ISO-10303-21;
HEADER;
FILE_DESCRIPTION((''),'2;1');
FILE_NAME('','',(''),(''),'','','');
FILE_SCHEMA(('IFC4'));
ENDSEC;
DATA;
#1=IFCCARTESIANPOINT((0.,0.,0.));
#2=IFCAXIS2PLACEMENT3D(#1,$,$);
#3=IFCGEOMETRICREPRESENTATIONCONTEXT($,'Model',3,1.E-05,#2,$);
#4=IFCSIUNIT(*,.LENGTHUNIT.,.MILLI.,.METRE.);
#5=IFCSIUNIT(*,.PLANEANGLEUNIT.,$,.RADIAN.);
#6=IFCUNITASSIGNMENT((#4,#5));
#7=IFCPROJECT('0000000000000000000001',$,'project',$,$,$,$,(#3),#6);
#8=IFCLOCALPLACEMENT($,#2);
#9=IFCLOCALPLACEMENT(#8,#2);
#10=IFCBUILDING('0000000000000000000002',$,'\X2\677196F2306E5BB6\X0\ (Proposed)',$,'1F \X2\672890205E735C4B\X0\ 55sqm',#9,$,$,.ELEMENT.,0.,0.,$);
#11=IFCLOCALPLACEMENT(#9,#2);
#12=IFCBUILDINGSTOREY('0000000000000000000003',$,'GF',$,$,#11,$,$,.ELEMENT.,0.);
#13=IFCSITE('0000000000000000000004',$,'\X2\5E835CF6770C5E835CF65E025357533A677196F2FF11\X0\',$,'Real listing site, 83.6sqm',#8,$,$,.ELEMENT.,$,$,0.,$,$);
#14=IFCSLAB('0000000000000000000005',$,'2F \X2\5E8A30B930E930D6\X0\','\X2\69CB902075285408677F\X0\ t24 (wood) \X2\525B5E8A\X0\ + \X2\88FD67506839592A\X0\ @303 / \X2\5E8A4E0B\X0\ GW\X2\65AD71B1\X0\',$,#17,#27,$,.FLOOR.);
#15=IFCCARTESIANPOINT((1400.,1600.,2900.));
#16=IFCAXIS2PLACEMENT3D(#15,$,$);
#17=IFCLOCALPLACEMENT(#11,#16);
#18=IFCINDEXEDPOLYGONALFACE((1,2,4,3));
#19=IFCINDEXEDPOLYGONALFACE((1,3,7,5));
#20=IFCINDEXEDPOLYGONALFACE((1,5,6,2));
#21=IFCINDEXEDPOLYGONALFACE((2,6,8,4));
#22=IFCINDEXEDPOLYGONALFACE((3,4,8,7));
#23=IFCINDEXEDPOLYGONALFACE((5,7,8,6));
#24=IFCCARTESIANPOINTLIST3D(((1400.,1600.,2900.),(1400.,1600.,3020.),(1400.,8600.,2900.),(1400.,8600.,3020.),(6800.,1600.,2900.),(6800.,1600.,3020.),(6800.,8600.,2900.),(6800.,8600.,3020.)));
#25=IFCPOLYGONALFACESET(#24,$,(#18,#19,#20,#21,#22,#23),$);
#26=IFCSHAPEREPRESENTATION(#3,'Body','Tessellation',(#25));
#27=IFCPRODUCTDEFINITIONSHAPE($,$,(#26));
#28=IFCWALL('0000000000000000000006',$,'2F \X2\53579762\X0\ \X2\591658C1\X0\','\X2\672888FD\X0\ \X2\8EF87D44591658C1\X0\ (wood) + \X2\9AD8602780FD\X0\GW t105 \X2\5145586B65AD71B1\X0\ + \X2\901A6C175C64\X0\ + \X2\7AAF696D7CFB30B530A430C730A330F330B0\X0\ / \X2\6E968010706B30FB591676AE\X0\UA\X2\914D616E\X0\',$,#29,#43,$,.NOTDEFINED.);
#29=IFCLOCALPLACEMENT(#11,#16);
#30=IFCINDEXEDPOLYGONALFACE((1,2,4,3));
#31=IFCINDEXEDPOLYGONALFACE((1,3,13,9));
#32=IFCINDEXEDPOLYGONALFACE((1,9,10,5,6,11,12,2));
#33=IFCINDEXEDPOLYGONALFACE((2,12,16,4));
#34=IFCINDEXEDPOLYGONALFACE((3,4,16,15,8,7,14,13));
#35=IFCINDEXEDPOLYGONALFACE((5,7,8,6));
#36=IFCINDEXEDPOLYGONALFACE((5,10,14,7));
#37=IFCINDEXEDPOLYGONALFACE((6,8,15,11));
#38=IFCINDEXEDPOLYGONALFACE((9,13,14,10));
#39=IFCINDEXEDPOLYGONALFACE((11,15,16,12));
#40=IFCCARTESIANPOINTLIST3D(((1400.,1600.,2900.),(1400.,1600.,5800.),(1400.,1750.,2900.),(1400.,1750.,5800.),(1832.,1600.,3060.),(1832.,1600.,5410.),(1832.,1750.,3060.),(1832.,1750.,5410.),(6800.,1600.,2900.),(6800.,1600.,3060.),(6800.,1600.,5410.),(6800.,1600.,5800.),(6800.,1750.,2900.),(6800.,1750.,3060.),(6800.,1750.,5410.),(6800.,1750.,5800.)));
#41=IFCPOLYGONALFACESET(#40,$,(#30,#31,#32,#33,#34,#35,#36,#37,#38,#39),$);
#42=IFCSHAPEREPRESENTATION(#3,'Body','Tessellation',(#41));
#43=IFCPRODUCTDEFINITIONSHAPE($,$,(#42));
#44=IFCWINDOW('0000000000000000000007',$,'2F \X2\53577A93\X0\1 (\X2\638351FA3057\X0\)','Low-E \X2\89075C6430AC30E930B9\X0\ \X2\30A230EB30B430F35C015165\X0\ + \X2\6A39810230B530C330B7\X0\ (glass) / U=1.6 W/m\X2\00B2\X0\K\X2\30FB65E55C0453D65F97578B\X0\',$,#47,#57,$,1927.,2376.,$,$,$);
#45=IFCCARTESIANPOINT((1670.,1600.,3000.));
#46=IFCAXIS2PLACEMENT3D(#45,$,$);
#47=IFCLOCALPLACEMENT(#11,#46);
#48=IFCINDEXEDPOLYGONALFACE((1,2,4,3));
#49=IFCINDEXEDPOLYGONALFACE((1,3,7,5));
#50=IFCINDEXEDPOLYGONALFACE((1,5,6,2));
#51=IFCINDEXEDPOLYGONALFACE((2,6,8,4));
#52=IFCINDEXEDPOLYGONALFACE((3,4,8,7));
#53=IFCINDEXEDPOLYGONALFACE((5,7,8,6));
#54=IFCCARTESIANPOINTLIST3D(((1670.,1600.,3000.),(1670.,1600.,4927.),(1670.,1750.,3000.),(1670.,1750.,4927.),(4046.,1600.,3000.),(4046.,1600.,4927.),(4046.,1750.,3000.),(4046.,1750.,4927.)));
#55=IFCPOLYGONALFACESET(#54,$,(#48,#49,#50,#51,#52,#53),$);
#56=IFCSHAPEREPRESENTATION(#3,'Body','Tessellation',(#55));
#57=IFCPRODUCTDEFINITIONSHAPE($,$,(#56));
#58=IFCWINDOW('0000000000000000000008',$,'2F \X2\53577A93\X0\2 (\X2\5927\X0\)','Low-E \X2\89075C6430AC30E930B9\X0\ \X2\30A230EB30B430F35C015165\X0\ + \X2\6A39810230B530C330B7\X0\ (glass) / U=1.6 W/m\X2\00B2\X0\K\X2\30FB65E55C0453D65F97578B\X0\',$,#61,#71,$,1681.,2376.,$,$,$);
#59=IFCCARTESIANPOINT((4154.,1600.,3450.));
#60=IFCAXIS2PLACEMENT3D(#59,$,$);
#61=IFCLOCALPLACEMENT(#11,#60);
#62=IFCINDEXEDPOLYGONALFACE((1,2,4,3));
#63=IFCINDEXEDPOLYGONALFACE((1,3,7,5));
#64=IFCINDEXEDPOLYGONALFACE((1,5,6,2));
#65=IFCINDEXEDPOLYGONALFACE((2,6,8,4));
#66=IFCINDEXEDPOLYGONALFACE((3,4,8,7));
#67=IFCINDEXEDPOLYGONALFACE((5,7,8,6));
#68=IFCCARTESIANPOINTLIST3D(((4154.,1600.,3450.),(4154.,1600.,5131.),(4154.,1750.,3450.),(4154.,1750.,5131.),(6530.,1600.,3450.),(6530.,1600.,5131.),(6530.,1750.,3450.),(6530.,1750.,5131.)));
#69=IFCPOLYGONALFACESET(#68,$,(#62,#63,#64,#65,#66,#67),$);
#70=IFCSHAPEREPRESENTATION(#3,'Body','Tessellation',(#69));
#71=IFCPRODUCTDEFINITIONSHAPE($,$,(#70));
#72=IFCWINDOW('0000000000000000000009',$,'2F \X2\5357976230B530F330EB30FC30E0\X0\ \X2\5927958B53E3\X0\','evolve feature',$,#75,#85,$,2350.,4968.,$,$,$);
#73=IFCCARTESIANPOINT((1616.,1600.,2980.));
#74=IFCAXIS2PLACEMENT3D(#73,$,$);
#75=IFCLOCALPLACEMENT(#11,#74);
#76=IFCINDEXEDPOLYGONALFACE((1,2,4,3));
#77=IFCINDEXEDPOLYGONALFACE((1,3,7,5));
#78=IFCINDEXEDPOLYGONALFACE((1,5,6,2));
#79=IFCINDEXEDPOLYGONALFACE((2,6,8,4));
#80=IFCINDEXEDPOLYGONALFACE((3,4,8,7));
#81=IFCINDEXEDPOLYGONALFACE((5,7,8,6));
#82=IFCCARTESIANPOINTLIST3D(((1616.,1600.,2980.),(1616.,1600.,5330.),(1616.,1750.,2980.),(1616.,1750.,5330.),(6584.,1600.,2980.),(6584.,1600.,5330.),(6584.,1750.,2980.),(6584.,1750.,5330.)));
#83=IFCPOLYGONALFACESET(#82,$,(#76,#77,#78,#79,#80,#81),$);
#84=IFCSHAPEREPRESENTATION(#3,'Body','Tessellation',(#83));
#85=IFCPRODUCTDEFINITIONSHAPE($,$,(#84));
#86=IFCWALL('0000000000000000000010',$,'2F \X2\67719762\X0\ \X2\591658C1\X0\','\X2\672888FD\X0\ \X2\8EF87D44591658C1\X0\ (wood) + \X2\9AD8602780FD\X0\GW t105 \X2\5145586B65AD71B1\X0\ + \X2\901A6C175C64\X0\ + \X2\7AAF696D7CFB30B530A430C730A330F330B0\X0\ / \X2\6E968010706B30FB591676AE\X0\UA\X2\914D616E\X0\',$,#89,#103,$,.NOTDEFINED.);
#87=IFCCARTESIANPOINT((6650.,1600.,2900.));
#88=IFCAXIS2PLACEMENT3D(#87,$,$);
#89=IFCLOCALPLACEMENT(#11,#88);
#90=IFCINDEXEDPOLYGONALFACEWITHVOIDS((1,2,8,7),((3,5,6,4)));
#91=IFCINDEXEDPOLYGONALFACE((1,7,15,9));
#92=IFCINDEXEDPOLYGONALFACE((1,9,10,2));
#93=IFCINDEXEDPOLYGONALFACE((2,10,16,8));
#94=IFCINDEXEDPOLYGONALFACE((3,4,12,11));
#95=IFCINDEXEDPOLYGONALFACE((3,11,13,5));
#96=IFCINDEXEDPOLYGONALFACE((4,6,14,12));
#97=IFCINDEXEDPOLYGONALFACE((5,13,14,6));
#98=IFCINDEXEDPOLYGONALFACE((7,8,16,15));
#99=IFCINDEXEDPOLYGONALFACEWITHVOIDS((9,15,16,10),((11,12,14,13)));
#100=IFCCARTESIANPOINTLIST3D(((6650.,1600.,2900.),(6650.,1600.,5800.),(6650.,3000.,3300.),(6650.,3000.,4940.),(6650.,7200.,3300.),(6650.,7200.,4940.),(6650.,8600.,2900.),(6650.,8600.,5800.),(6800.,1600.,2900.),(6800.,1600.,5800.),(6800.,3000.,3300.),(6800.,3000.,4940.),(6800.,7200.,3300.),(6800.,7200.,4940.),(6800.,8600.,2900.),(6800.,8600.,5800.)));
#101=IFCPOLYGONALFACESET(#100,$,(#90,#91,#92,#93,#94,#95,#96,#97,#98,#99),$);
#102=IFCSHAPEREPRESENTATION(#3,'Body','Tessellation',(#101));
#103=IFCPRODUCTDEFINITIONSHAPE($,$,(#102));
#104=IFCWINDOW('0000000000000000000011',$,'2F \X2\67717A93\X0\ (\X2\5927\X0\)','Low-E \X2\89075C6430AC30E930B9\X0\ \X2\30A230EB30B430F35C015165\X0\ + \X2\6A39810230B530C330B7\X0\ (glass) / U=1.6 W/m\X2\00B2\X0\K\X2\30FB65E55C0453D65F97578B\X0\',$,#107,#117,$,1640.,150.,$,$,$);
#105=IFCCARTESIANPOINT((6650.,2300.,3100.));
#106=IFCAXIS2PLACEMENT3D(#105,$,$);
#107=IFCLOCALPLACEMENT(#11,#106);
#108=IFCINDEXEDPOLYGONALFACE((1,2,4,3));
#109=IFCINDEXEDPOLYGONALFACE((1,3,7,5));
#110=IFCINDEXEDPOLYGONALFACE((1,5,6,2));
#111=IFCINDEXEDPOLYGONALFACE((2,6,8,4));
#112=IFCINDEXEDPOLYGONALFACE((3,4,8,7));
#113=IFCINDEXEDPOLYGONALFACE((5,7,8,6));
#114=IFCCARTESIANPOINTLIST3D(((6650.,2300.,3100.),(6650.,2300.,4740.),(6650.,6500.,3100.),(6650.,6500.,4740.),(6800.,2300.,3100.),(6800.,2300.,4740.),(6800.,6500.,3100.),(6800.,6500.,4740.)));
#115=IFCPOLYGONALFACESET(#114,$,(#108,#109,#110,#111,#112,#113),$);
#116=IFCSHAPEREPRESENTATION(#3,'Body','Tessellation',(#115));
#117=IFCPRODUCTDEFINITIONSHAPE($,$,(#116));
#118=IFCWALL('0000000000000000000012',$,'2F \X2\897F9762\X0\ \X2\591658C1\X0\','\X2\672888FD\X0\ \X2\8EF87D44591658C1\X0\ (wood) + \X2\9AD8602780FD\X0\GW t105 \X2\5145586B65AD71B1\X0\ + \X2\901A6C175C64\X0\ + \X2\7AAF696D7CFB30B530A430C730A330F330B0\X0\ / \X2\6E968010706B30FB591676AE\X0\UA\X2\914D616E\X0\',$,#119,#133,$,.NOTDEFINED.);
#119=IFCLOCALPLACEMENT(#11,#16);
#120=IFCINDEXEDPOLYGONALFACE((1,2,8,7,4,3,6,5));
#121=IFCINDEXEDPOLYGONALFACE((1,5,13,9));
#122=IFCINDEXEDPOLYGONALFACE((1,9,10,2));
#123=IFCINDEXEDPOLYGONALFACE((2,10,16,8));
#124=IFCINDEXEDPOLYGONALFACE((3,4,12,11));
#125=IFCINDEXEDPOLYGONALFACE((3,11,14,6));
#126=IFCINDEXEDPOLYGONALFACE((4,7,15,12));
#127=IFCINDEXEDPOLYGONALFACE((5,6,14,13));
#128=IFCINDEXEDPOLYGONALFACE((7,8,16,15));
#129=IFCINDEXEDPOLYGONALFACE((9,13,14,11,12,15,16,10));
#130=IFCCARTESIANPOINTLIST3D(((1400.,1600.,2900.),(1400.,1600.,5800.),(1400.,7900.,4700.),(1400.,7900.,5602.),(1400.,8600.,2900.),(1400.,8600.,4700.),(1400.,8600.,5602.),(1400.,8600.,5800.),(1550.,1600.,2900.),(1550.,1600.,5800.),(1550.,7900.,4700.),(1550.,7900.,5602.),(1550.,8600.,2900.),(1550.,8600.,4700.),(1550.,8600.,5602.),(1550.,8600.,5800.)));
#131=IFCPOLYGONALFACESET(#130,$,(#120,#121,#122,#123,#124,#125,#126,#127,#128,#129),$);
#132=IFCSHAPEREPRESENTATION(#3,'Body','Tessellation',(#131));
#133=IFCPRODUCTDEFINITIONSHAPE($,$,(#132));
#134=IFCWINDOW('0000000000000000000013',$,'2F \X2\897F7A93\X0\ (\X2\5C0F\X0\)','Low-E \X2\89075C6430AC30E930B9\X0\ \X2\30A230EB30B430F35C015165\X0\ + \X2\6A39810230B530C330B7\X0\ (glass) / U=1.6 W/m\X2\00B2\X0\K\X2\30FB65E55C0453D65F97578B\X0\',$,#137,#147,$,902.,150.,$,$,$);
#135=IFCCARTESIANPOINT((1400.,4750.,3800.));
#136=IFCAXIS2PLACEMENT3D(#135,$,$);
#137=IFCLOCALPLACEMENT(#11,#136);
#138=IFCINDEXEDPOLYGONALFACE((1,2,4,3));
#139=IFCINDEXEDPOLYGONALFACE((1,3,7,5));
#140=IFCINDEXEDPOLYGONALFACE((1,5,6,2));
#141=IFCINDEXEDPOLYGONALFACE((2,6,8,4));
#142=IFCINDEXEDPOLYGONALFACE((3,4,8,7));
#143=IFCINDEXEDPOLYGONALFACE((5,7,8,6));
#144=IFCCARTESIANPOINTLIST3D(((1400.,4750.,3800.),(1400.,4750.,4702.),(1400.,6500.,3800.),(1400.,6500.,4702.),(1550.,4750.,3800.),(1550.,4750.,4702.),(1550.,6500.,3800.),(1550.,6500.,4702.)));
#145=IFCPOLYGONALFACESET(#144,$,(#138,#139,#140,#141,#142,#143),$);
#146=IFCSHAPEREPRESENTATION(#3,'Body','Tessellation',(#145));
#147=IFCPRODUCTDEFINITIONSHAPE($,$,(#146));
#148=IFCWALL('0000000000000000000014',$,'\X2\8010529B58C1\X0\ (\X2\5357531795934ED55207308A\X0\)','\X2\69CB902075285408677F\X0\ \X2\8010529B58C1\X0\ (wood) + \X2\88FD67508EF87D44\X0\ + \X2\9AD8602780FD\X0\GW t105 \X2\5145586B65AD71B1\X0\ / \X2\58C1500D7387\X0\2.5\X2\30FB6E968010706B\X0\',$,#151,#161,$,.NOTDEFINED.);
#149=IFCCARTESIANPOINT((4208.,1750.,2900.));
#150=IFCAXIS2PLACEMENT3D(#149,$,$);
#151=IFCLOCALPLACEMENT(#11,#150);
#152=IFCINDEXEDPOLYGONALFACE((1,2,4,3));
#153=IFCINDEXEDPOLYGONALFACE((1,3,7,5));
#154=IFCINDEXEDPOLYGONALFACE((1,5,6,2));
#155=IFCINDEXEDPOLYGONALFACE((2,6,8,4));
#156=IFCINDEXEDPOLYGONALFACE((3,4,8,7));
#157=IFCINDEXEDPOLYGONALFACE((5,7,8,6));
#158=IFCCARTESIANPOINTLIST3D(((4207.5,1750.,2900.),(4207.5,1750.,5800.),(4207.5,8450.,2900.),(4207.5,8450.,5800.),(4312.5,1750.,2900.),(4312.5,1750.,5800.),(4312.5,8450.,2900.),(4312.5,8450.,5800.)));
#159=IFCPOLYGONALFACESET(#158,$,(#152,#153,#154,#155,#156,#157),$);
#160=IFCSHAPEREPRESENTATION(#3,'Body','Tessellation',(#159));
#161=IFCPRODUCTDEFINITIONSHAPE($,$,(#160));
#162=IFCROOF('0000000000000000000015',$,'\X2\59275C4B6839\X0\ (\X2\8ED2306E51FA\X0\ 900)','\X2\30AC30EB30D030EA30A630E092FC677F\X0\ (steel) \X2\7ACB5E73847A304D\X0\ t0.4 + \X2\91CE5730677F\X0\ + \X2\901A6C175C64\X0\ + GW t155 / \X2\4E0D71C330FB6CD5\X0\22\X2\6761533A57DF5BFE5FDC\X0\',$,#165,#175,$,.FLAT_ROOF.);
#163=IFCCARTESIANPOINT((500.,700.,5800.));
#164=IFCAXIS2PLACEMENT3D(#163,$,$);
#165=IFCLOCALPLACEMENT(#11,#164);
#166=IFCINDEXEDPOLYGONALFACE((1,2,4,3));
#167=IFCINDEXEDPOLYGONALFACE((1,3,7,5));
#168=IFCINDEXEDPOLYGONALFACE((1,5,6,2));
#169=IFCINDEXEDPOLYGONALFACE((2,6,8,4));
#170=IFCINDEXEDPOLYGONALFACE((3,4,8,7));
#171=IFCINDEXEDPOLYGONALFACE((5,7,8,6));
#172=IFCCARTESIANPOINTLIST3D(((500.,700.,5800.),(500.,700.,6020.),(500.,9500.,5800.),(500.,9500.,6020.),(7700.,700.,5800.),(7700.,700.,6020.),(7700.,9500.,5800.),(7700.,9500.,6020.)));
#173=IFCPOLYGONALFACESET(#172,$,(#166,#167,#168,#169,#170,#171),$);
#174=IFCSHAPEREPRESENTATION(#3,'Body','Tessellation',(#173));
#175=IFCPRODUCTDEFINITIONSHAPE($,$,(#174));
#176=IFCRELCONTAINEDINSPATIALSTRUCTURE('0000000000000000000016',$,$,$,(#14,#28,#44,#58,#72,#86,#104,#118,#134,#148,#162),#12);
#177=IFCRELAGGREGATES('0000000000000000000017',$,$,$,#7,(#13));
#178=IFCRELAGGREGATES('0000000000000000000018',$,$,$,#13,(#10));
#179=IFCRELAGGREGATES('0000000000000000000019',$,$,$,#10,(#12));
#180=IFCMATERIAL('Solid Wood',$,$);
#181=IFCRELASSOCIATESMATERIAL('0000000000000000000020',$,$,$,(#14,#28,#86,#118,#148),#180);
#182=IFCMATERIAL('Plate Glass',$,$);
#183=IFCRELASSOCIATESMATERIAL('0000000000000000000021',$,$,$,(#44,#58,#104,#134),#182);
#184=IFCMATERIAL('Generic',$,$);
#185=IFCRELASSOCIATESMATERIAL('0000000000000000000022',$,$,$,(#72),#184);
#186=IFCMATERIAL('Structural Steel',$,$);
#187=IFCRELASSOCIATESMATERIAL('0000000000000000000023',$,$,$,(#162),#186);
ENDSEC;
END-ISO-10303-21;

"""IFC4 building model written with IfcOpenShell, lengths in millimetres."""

from ifc_helpers import new_model, si_unit, frame, frame_2d, origin, place, context, project, spatial, rectangle, extrude, material, element, fill, save


model = new_model("IFC4")

# Units and contexts
model_context = context("Model", 3, precision=1e-05, world=origin())
ifc_project = project(units=[si_unit("LENGTHUNIT", "METRE", prefix="MILLI"), si_unit("PLANEANGLEUNIT", "RADIAN")], contexts=[model_context])

# Site, building, storey
site_placement = place(None, origin())
site = spatial("IfcSite", under=ifc_project, at=site_placement, Name="広島県広島市南区東雲１", ObjectType="Real listing site, 83.6sqm", CompositionType="ELEMENT", RefElevation=0.0)
building_placement = place(site_placement, origin())
building = spatial("IfcBuilding", under=site, at=building_placement, Name="東雲の家 (Proposed)", ObjectType="1F 木造平屋 55sqm", CompositionType="ELEMENT", ElevationOfRefHeight=0.0, ElevationOfTerrain=0.0)
storey_placement = place(building_placement, origin())
storey = spatial("IfcBuildingStorey", under=building, at=storey_placement, Name="GF", CompositionType="ELEMENT", Elevation=0.0)

# Slab
ifc_material_1 = material(Name="Solid Wood")
slab_placement = place(storey_placement, frame((1400.0, 1600.0, 2900.0)))
element("IfcSlab", 1, at=slab_placement, inside=storey, material=ifc_material_1, Name="2F 床スラブ", Description="構造用合板 t24 (wood) 剛床 + 製材根太 @303 / 床下 GW断熱", PredefinedType="FLOOR", context=model_context, shape_type="SweptSolid", body=[
    extrude(rectangle(XDim=5400.0, YDim=7000.0, at=frame_2d((2700.0, 3500.0))), frame((1400.0, 1600.0, 2900.0)), (0.0, 0.0, 1.0), 120.0),
])

# Wall, openings, windows
wall_1_placement = place(storey_placement, frame((1400.0, 1600.0, 2900.0)))
wall_1 = element("IfcWall", 2, at=wall_1_placement, inside=storey, material=ifc_material_1, Name="2F 南面 外壁", Description="木製 軸組外壁 (wood) + 高性能GW t105 充填断熱 + 通気層 + 窯業系サイディング / 準耐火・外皮UA配慮", PredefinedType="NOTDEFINED", context=model_context, shape_type="SweptSolid", body=[
    extrude(rectangle(XDim=5400.0, YDim=150.0, at=frame_2d((2700.0, 75.0))), frame((1400.0, 1600.0, 2900.0)), (0.0, 0.0, 1.0), 2900.0),
])
opening_1_placement = place(storey_placement, frame((1670.0, 1600.0, 3000.0)))
opening_1 = element("IfcOpeningElement", 3, at=opening_1_placement, cuts=wall_1, PredefinedType="NOTDEFINED", context=model_context, shape_type="SweptSolid", body=[
    extrude(rectangle(XDim=2376.0, YDim=150.0, at=frame_2d((1188.0, 75.0))), frame((1670.0, 1600.0, 3000.0)), (0.0, 0.0, 1.0), 1927.0),
])
opening_2_placement = place(storey_placement, frame((4154.0, 1600.0, 3450.0)))
opening_2 = element("IfcOpeningElement", 4, at=opening_2_placement, cuts=wall_1, PredefinedType="NOTDEFINED", context=model_context, shape_type="SweptSolid", body=[
    extrude(rectangle(XDim=2376.0, YDim=150.0, at=frame_2d((1188.0, 75.0))), frame((4154.0, 1600.0, 3450.0)), (0.0, 0.0, 1.0), 1681.0),
])
opening_3_placement = place(storey_placement, frame((1616.0, 1600.0, 2980.0)))
opening_3 = element("IfcOpeningElement", 5, at=opening_3_placement, cuts=wall_1, PredefinedType="NOTDEFINED", context=model_context, shape_type="SweptSolid", body=[
    extrude(rectangle(XDim=4968.0, YDim=150.0, at=frame_2d((2484.0, 75.0))), frame((1616.0, 1600.0, 2980.0)), (0.0, 0.0, 1.0), 2350.0),
])
ifc_material_2 = material(Name="Plate Glass")
window_1_placement = place(storey_placement, frame((1670.0, 1600.0, 3000.0)))
window_1 = element("IfcWindow", 6, at=window_1_placement, inside=storey, material=ifc_material_2, Name="2F 南窓1 (掃出し)", Description="Low-E 複層ガラス アルゴン封入 + 樹脂サッシ (glass) / U=1.6 W/m²K・日射取得型", OverallHeight=1927.0, OverallWidth=2376.0, context=model_context, shape_type="SweptSolid", body=[
    extrude(rectangle(XDim=2376.0, YDim=150.0, at=frame_2d((1188.0, 75.0))), frame((1670.0, 1600.0, 3000.0)), (0.0, 0.0, 1.0), 1927.0),
])
fill(opening_1, window_1)
window_2_placement = place(storey_placement, frame((4154.0, 1600.0, 3450.0)))
window_2 = element("IfcWindow", 7, at=window_2_placement, inside=storey, material=ifc_material_2, Name="2F 南窓2 (大)", Description="Low-E 複層ガラス アルゴン封入 + 樹脂サッシ (glass) / U=1.6 W/m²K・日射取得型", OverallHeight=1681.0, OverallWidth=2376.0, context=model_context, shape_type="SweptSolid", body=[
    extrude(rectangle(XDim=2376.0, YDim=150.0, at=frame_2d((1188.0, 75.0))), frame((4154.0, 1600.0, 3450.0)), (0.0, 0.0, 1.0), 1681.0),
])
fill(opening_2, window_2)
ifc_material_3 = material(Name="Generic")
window_3_placement = place(storey_placement, frame((1616.0, 1600.0, 2980.0)))
window_3 = element("IfcWindow", 8, at=window_3_placement, inside=storey, material=ifc_material_3, Name="2F 南面サンルーム 大開口", Description="evolve feature", OverallHeight=2350.0, OverallWidth=4968.0, context=model_context, shape_type="SweptSolid", body=[
    extrude(rectangle(XDim=4968.0, YDim=150.0, at=frame_2d((2484.0, 75.0))), frame((1616.0, 1600.0, 2980.0)), (0.0, 0.0, 1.0), 2350.0),
])
fill(opening_3, window_3)

# Walls, openings, windows
wall_2_placement = place(storey_placement, frame((6650.0, 1600.0, 2900.0)))
wall_2 = element("IfcWall", 9, at=wall_2_placement, inside=storey, material=ifc_material_1, Name="2F 東面 外壁", Description="木製 軸組外壁 (wood) + 高性能GW t105 充填断熱 + 通気層 + 窯業系サイディング / 準耐火・外皮UA配慮", PredefinedType="NOTDEFINED", context=model_context, shape_type="SweptSolid", body=[
    extrude(rectangle(XDim=150.0, YDim=7000.0, at=frame_2d((75.0, 3500.0))), frame((6650.0, 1600.0, 2900.0)), (0.0, 0.0, 1.0), 2900.0),
])
opening_4_placement = place(storey_placement, frame((6650.0, 2300.0, 3100.0)))
opening_4 = element("IfcOpeningElement", 10, at=opening_4_placement, cuts=wall_2, PredefinedType="NOTDEFINED", context=model_context, shape_type="SweptSolid", body=[
    extrude(rectangle(XDim=150.0, YDim=4200.0, at=frame_2d((75.0, 2100.0))), frame((6650.0, 2300.0, 3100.0)), (0.0, 0.0, 1.0), 1640.0),
])
window_4_placement = place(storey_placement, frame((6650.0, 2300.0, 3100.0)))
window_4 = element("IfcWindow", 11, at=window_4_placement, inside=storey, material=ifc_material_2, Name="2F 東窓 (大)", Description="Low-E 複層ガラス アルゴン封入 + 樹脂サッシ (glass) / U=1.6 W/m²K・日射取得型", OverallHeight=1640.0, OverallWidth=150.0, context=model_context, shape_type="SweptSolid", body=[
    extrude(rectangle(XDim=150.0, YDim=4200.0, at=frame_2d((75.0, 2100.0))), frame((6650.0, 2300.0, 3100.0)), (0.0, 0.0, 1.0), 1640.0),
])
fill(opening_4, window_4)
wall_3_placement = place(storey_placement, frame((1400.0, 1600.0, 2900.0)))
wall_3 = element("IfcWall", 12, at=wall_3_placement, inside=storey, material=ifc_material_1, Name="2F 西面 外壁", Description="木製 軸組外壁 (wood) + 高性能GW t105 充填断熱 + 通気層 + 窯業系サイディング / 準耐火・外皮UA配慮", PredefinedType="NOTDEFINED", context=model_context, shape_type="SweptSolid", body=[
    extrude(rectangle(XDim=150.0, YDim=7000.0, at=frame_2d((75.0, 3500.0))), frame((1400.0, 1600.0, 2900.0)), (0.0, 0.0, 1.0), 2900.0),
])
opening_5_placement = place(storey_placement, frame((1400.0, 4750.0, 3800.0)))
opening_5 = element("IfcOpeningElement", 13, at=opening_5_placement, cuts=wall_3, PredefinedType="NOTDEFINED", context=model_context, shape_type="SweptSolid", body=[
    extrude(rectangle(XDim=150.0, YDim=1750.0, at=frame_2d((75.0, 875.0))), frame((1400.0, 4750.0, 3800.0)), (0.0, 0.0, 1.0), 902.0),
])
window_5_placement = place(storey_placement, frame((1400.0, 4750.0, 3800.0)))
window_5 = element("IfcWindow", 14, at=window_5_placement, inside=storey, material=ifc_material_2, Name="2F 西窓 (小)", Description="Low-E 複層ガラス アルゴン封入 + 樹脂サッシ (glass) / U=1.6 W/m²K・日射取得型", OverallHeight=902.0, OverallWidth=150.0, context=model_context, shape_type="SweptSolid", body=[
    extrude(rectangle(XDim=150.0, YDim=1750.0, at=frame_2d((75.0, 875.0))), frame((1400.0, 4750.0, 3800.0)), (0.0, 0.0, 1.0), 902.0),
])
fill(opening_5, window_5)

# Wall
wall_4_placement = place(storey_placement, frame((4208.0, 1750.0, 2900.0)))
element("IfcWall", 15, at=wall_4_placement, inside=storey, material=ifc_material_1, Name="耐力壁 (南北間仕切り)", Description="構造用合板 耐力壁 (wood) + 製材軸組 + 高性能GW t105 充填断熱 / 壁倍率2.5・準耐火", PredefinedType="NOTDEFINED", context=model_context, shape_type="SweptSolid", body=[
    extrude(rectangle(XDim=105.0, YDim=6700.0, at=frame_2d((52.0, 3350.0))), frame((4208.0, 1750.0, 2900.0)), (0.0, 0.0, 1.0), 2900.0),
])

# Roof
ifc_material_4 = material(Name="Structural Steel")
roof_placement = place(storey_placement, frame((500.0, 700.0, 5800.0)))
element("IfcRoof", 16, at=roof_placement, inside=storey, material=ifc_material_4, Name="大屋根 (軒の出 900)", Description="ガルバリウム鋼板 (steel) 立平葺き t0.4 + 野地板 + 通気層 + GW t155 / 不燃・法22条区域対応", PredefinedType="FLAT_ROOF", context=model_context, shape_type="SweptSolid", body=[
    extrude(rectangle(XDim=7200.0, YDim=8800.0, at=frame_2d((3600.0, 4400.0))), frame((500.0, 700.0, 5800.0)), (0.0, 0.0, 1.0), 220.0),
])

save(model, "model.ifc")
